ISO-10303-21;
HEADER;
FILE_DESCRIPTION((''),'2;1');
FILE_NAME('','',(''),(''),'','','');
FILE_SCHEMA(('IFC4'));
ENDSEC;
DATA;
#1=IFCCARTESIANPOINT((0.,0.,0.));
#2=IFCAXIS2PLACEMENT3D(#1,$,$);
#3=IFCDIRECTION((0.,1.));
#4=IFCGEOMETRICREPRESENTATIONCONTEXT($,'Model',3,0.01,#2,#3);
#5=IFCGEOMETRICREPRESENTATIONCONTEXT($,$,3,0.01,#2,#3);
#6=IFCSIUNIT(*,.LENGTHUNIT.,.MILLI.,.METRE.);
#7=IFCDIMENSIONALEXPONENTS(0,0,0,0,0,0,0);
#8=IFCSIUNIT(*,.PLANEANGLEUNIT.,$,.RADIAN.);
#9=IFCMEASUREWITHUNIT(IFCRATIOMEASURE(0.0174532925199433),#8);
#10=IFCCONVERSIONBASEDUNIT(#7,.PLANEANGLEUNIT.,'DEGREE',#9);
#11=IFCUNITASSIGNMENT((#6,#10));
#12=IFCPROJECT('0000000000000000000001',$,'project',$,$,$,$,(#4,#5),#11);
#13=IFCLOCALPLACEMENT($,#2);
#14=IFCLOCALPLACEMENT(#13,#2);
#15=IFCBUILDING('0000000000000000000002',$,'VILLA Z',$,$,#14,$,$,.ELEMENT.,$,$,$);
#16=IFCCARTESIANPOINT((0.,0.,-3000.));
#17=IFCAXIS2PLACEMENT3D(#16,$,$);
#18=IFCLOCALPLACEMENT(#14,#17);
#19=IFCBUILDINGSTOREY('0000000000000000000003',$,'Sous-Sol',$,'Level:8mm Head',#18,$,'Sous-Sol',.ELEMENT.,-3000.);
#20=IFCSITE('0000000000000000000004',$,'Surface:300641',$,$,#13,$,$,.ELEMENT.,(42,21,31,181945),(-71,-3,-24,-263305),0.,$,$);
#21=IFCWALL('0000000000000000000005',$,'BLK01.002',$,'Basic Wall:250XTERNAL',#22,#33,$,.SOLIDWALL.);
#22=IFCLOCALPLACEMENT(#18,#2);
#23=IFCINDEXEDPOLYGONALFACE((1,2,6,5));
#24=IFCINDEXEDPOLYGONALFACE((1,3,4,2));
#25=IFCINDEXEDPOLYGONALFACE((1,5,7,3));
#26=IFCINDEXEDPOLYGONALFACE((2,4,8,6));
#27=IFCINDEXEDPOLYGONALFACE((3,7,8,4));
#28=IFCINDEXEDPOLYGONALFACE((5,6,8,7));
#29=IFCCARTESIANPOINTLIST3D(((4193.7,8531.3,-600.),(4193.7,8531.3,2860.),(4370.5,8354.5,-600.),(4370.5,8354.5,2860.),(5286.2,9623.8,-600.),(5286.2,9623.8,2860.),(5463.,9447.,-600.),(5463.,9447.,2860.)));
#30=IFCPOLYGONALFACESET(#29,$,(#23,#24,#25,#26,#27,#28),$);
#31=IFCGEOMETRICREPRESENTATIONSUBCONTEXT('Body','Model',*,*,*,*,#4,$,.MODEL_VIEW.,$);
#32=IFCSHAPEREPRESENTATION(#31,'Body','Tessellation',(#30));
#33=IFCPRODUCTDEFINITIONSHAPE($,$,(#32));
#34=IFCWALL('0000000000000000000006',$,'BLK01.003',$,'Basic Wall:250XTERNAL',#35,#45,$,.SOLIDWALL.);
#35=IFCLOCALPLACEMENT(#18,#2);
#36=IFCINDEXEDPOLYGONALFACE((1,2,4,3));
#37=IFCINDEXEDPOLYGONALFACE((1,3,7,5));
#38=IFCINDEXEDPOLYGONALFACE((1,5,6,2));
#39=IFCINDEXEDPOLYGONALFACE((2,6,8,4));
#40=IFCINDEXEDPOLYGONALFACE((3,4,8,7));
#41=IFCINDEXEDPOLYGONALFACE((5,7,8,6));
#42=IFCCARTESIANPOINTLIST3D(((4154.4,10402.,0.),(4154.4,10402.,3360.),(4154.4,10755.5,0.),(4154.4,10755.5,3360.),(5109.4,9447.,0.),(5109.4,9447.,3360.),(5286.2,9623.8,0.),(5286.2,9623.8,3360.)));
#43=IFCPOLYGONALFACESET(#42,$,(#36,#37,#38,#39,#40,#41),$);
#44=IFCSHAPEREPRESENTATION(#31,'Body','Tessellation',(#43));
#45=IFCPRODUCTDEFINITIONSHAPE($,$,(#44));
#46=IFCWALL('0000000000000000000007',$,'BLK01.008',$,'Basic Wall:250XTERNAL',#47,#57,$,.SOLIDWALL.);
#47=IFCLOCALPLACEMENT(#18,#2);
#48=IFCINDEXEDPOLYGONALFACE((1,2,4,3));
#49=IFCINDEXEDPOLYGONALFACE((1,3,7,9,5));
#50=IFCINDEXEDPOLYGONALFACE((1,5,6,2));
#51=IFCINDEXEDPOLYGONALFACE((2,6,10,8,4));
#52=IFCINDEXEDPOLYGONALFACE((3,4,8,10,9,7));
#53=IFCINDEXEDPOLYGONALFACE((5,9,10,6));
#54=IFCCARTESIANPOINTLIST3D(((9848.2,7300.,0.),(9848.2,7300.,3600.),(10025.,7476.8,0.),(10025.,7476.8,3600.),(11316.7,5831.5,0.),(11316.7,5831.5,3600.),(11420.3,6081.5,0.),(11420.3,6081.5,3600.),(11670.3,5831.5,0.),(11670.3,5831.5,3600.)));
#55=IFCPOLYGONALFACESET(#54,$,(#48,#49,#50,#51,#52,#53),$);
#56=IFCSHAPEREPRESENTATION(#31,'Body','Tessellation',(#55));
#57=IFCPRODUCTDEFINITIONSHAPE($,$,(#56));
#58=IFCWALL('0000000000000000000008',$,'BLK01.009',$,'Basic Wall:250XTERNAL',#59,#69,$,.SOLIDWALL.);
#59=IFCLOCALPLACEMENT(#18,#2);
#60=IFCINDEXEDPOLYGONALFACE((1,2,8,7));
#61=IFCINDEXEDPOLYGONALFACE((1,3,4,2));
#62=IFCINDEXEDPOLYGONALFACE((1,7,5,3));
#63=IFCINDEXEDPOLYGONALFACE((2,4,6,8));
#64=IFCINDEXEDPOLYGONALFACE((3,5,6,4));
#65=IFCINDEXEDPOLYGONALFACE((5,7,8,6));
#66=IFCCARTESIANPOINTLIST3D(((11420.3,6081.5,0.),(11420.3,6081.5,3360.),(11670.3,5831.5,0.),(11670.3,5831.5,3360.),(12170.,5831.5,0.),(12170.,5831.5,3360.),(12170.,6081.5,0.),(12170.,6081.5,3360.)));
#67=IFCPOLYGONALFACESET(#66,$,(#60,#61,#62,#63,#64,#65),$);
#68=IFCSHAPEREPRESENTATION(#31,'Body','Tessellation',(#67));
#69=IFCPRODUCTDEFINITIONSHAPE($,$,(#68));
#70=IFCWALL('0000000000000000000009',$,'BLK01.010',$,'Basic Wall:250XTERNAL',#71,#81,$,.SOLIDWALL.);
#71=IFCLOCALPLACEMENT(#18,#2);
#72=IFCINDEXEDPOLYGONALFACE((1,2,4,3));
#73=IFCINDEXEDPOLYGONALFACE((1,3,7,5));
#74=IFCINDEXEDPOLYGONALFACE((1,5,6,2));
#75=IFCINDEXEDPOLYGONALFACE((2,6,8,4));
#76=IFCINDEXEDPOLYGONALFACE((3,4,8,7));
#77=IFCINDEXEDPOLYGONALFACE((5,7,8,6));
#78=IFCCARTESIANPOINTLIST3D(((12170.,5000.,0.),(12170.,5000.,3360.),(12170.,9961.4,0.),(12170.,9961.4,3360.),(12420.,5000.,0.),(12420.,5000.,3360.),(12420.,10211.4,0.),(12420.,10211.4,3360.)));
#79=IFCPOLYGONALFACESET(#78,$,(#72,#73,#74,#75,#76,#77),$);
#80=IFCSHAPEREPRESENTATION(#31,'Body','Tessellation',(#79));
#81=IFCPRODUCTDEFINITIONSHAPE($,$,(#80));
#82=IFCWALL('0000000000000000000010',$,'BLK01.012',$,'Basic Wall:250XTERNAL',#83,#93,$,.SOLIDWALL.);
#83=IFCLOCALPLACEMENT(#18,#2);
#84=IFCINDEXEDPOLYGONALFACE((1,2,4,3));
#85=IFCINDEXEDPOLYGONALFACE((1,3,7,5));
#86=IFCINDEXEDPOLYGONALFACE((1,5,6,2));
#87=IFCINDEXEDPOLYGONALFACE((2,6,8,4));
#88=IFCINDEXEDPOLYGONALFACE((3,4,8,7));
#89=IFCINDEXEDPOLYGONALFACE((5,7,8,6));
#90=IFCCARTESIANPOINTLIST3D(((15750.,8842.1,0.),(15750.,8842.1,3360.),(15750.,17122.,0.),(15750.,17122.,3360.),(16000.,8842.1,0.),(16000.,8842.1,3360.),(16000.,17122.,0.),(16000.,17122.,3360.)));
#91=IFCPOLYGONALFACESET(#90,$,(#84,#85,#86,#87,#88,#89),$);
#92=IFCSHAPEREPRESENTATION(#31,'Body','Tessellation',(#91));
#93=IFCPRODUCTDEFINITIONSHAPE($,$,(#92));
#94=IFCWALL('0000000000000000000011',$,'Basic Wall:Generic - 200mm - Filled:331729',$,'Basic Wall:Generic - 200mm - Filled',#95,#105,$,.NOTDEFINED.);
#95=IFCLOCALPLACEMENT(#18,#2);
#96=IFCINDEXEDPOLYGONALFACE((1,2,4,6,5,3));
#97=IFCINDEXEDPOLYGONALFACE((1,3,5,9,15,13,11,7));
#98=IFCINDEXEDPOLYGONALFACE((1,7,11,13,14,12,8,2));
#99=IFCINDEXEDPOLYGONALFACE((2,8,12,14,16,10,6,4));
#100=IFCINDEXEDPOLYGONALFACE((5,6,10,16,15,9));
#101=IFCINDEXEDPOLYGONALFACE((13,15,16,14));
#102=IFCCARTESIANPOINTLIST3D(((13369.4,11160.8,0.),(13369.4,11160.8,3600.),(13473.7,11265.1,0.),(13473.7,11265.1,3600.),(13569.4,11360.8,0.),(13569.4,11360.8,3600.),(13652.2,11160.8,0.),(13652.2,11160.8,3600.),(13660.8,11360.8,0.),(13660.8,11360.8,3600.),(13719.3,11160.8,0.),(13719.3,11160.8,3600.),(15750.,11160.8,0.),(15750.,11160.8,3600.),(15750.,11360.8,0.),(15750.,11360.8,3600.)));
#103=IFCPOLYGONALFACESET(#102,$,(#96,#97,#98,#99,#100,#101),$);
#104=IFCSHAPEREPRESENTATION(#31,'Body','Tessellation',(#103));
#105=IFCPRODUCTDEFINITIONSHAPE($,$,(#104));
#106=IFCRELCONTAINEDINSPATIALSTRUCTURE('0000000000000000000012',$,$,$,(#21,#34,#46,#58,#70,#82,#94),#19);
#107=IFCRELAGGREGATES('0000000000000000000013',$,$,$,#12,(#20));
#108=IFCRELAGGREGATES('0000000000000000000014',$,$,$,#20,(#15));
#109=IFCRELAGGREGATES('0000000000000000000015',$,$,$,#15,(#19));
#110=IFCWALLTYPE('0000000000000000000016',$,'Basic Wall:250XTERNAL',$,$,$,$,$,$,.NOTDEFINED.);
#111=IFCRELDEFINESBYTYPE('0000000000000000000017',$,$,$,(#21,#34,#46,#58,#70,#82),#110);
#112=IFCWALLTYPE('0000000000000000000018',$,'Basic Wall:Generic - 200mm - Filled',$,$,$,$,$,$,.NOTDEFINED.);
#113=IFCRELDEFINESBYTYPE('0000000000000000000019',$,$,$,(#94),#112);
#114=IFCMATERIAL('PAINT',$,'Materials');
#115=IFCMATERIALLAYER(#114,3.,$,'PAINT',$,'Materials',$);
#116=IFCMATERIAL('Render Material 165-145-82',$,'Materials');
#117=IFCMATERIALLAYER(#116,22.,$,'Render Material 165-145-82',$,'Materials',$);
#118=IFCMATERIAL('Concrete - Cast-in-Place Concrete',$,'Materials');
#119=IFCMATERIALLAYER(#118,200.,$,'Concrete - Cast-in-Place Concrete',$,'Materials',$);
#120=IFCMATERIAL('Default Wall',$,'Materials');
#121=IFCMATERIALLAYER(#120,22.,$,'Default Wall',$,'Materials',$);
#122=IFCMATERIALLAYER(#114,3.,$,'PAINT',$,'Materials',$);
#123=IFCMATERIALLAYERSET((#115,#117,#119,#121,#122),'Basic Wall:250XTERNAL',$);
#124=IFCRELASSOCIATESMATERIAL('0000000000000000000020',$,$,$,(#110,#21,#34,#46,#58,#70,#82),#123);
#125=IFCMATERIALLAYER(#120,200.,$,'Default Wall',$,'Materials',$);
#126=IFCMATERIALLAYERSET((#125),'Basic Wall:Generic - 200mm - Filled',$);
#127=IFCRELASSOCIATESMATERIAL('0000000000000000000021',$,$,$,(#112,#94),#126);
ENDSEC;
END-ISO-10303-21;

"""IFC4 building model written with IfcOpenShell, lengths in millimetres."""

from ifc_helpers import new_model, entity, si_unit, converted_unit, direction, frame, frame_2d, origin, place, context, subcontext, project, spatial, polyline, rectangle, outline, extrude, clip, halfspace, bounded_halfspace, material, layer, layer_set, layer_usage, type_object, element, save


model = new_model("IFC4")

# Units and contexts
model_context = context("Model", 3, precision=0.01, world=origin(), true_north=direction((0.0, 1.0)))
context_of_model = context(None, 3, precision=0.01, world=origin(), true_north=direction((0.0, 1.0)))
body_context = subcontext(model_context, "Body", "Model", "MODEL_VIEW")
ifc_project = project(units=[si_unit("LENGTHUNIT", "METRE", prefix="MILLI"), converted_unit("PLANEANGLEUNIT", "DEGREE", entity("IfcRatioMeasure", 0.0174532925199433), si_unit("PLANEANGLEUNIT", "RADIAN"), dimensions=[0, 0, 0, 0, 0, 0, 0])], contexts=[model_context, context_of_model])

# Site, building, storey
site_placement = place(None, origin())
site = spatial("IfcSite", under=ifc_project, at=site_placement, Name="Surface:300641", CompositionType="ELEMENT", RefLatitude=(42, 21, 31, 181945), RefLongitude=(-71, -3, -24, -263305), RefElevation=0.0)
building_placement = place(site_placement, origin())
building = spatial("IfcBuilding", under=site, at=building_placement, Name="VILLA Z", CompositionType="ELEMENT")
storey_placement = place(building_placement, frame((0.0, 0.0, -3000.0)))
storey = spatial("IfcBuildingStorey", under=building, at=storey_placement, Name="Sous-Sol", ObjectType="Level:8mm Head", LongName="Sous-Sol", CompositionType="ELEMENT", Elevation=-3000.0)

# Walls
ifc_material_1 = material(Name="PAINT", Category="Materials")
ifc_layer_1 = layer(ifc_material_1, 3.0, Name="PAINT", Category="Materials")
ifc_material_2 = material(Name="Render Material 165-145-82", Category="Materials")
ifc_layer_2 = layer(ifc_material_2, 22.0, Name="Render Material 165-145-82", Category="Materials")
ifc_material_3 = material(Name="Concrete - Cast-in-Place Concrete", Category="Materials")
ifc_layer_3 = layer(ifc_material_3, 200.0, Name="Concrete - Cast-in-Place Concrete", Category="Materials")
ifc_material_4 = material(Name="Default Wall", Category="Materials")
ifc_layer_4 = layer(ifc_material_4, 22.0, Name="Default Wall", Category="Materials")
ifc_layer_5 = layer(ifc_material_1, 3.0, Name="PAINT", Category="Materials")
ifc_layer_set_1 = layer_set([ifc_layer_1, ifc_layer_2, ifc_layer_3, ifc_layer_4, ifc_layer_5], Name="Basic Wall:250XTERNAL")
ifc_layer_usage_1 = layer_usage(ifc_layer_set_1, "AXIS2", "NEGATIVE", 125.0)
wall_type_1 = type_object("IfcWallType", Name="Basic Wall:250XTERNAL", PredefinedType="NOTDEFINED", material=ifc_layer_set_1)
wall_1_placement = place(storey_placement, frame((4282.1, 8442.9, -600.0), z_axis=(0.0, 0.0, 1.0), x_axis=(0.707107, 0.707107, 0.0)))
element("IfcWall", 1, at=wall_1_placement, inside=storey, type_object=wall_type_1, material=ifc_layer_usage_1, Name="BLK01.002", ObjectType="Basic Wall:250XTERNAL", PredefinedType="SOLIDWALL", context=body_context, shape_type="Clipping", body=[
    clip(extrude(rectangle(XDim=1545.0, YDim=250.0, at=frame_2d((772.5, 0.0), x_axis=(-1.0, 0.0))), origin(), (0.0, 0.0, 1.0), 3460.0), bounded_halfspace(frame((0.0, -125.0, 3460.0), z_axis=(0.0, 0.0, -1.0), x_axis=(0.707107, -0.707107, 0.0)), True, frame((0.0, -125.0, 3460.0)), polyline([(0.0, 0.0), (1545.0, 0.0), (1545.0, 250.0), (0.0, 250.0), (0.0, 0.0)]))),
])
ifc_layer_usage_2 = layer_usage(ifc_layer_set_1, "AXIS2", "NEGATIVE", 125.0)
wall_2_placement = place(storey_placement, frame((5374.6, 9358.6, 0.0), z_axis=(0.0, 0.0, 1.0), x_axis=(-0.707107, 0.707107, 0.0)))
element("IfcWall", 2, at=wall_2_placement, inside=storey, type_object=wall_type_1, material=ifc_layer_usage_2, Name="BLK01.003", ObjectType="Basic Wall:250XTERNAL", PredefinedType="SOLIDWALL", context=body_context, shape_type="Clipping", body=[
    clip(extrude(outline(polyline([(1850.5, -125.0), (1600.5, 125.0), (250.0, 125.0), (250.0, -125.0), (1850.5, -125.0)])), origin(), (0.0, 0.0, 1.0), 3360.0), bounded_halfspace(frame((250.0, -125.0, 3360.0), z_axis=(0.0, 0.0, -1.0), x_axis=(-0.707107, 0.707107, 0.0)), True, frame((250.0, -125.0, 3360.0)), polyline([(0.0, 0.0), (1600.5, 0.0), (1350.5, 250.0), (0.0, 250.0), (0.0, 0.0)]))),
])

# Walls
ifc_layer_usage_3 = layer_usage(ifc_layer_set_1, "AXIS2", "NEGATIVE", 125.0)
wall_3_placement = place(storey_placement, frame((9936.6, 7388.4, 0.0), z_axis=(0.0, 0.0, 1.0), x_axis=(0.707107, -0.707107, 0.0)))
element("IfcWall", 3, at=wall_3_placement, inside=storey, type_object=wall_type_1, material=ifc_layer_usage_3, Name="BLK01.008", ObjectType="Basic Wall:250XTERNAL", PredefinedType="SOLIDWALL", context=body_context, shape_type="SweptSolid", body=[
    extrude(outline(polyline([(2076.8, -125.0), (2326.8, 125.0), (1973.2, 125.0), (0.0, 125.0), (0.0, -125.0), (2076.8, -125.0)])), origin(), (0.0, 0.0, 1.0), 3600.0),
])
ifc_layer_usage_4 = layer_usage(ifc_layer_set_1, "AXIS2", "NEGATIVE", 125.0)
wall_4_placement = place(storey_placement, frame((11420.3, 5956.5, 0.0)))
element("IfcWall", 4, at=wall_4_placement, inside=storey, type_object=wall_type_1, material=ifc_layer_usage_4, Name="BLK01.009", ObjectType="Basic Wall:250XTERNAL", PredefinedType="SOLIDWALL", context=body_context, shape_type="Clipping", body=[
    clip(extrude(outline(polyline([(749.7, -125.0), (749.7, 125.0), (0.0, 125.0), (250.0, -125.0), (749.7, -125.0)])), origin(), (0.0, 0.0, 1.0), 3360.0), bounded_halfspace(frame((250.0, -125.0, 3360.0), z_axis=(0.0, 0.0, -1.0), x_axis=(0.0, -1.0, 0.0)), True, frame((250.0, -125.0, 3360.0)), polyline([(0.0, 0.0), (499.7, 0.0), (499.7, 250.0), (-250.0, 250.0), (0.0, 0.0)]))),
])
ifc_layer_usage_5 = layer_usage(ifc_layer_set_1, "AXIS2", "NEGATIVE", 125.0)
wall_5_placement = place(storey_placement, frame((12295.0, 5000.0, 0.0), z_axis=(0.0, 0.0, 1.0), x_axis=(0.0, 1.0, 0.0)))
element("IfcWall", 5, at=wall_5_placement, inside=storey, type_object=wall_type_1, material=ifc_layer_usage_5, Name="BLK01.010", ObjectType="Basic Wall:250XTERNAL", PredefinedType="SOLIDWALL", context=body_context, shape_type="Clipping", body=[
    clip(extrude(outline(polyline([(5211.4, -125.0), (4961.4, 125.0), (1081.5, 125.0), (831.5, 125.0), (0.0, 125.0), (0.0, -125.0), (150.0, -125.0), (4928.6, -125.0), (5211.4, -125.0)])), origin(), (0.0, 0.0, 1.0), 3360.0), bounded_halfspace(frame((0.0, -125.0, 3360.0), z_axis=(0.0, 0.0, -1.0), x_axis=(-1.0, 0.0, 0.0)), True, frame((0.0, -125.0, 3360.0)), polyline([(0.0, 0.0), (150.0, 0.0), (5211.4, 0.0), (4961.4, 250.0), (1081.5, 250.0), (831.5, 250.0), (0.0, 250.0), (0.0, 0.0)]))),
])
ifc_layer_usage_6 = layer_usage(ifc_layer_set_1, "AXIS2", "NEGATIVE", 125.0)
wall_6_placement = place(storey_placement, frame((15875.0, 8842.1, 0.0), z_axis=(0.0, 0.0, 1.0), x_axis=(0.0, 1.0, 0.0)))
element("IfcWall", 6, at=wall_6_placement, inside=storey, type_object=wall_type_1, material=ifc_layer_usage_6, Name="BLK01.012", ObjectType="Basic Wall:250XTERNAL", PredefinedType="SOLIDWALL", context=body_context, shape_type="Clipping", body=[
    clip(clip(extrude(rectangle(XDim=8279.9, YDim=250.0, at=frame_2d((4140.0, 0.0), x_axis=(-1.0, 0.0))), origin(), (0.0, 0.0, 1.0), 3360.0), bounded_halfspace(frame((0.0, 125.0, 3360.0), z_axis=(0.0, 0.0, -1.0), x_axis=(-1.0, 0.0, 0.0)), True, frame((0.0, 125.0, 3360.0)), polyline([(0.0, 0.0), (0.0, -250.0), (8279.9, -250.0), (8279.9, 0.0), (0.0, 0.0)]))), halfspace(origin(), True)),
])
ifc_layer_6 = layer(ifc_material_4, 200.0, Name="Default Wall", Category="Materials")
ifc_layer_set_2 = layer_set([ifc_layer_6], Name="Basic Wall:Generic - 200mm - Filled")
ifc_layer_usage_7 = layer_usage(ifc_layer_set_2, "AXIS2", "NEGATIVE", 100.0)
wall_type_2 = type_object("IfcWallType", Name="Basic Wall:Generic - 200mm - Filled", PredefinedType="NOTDEFINED", material=ifc_layer_set_2)
wall_7_placement = place(storey_placement, frame((13369.4, 11260.8, 0.0)))
element("IfcWall", 7, at=wall_7_placement, inside=storey, type_object=wall_type_2, material=ifc_layer_usage_7, Name="Basic Wall:Generic - 200mm - Filled:331729", ObjectType="Basic Wall:Generic - 200mm - Filled", PredefinedType="NOTDEFINED", context=body_context, shape_type="SweptSolid", body=[
    extrude(outline(polyline([(2380.6, -100.0), (2380.6, 100.0), (291.4, 100.0), (200.0, 100.0), (104.3, 4.3), (0.0, -100.0), (282.8, -100.0), (349.9, -100.0), (2380.6, -100.0)])), origin(), (0.0, 0.0, 1.0), 3600.0),
])

save(model, "model.ifc")
